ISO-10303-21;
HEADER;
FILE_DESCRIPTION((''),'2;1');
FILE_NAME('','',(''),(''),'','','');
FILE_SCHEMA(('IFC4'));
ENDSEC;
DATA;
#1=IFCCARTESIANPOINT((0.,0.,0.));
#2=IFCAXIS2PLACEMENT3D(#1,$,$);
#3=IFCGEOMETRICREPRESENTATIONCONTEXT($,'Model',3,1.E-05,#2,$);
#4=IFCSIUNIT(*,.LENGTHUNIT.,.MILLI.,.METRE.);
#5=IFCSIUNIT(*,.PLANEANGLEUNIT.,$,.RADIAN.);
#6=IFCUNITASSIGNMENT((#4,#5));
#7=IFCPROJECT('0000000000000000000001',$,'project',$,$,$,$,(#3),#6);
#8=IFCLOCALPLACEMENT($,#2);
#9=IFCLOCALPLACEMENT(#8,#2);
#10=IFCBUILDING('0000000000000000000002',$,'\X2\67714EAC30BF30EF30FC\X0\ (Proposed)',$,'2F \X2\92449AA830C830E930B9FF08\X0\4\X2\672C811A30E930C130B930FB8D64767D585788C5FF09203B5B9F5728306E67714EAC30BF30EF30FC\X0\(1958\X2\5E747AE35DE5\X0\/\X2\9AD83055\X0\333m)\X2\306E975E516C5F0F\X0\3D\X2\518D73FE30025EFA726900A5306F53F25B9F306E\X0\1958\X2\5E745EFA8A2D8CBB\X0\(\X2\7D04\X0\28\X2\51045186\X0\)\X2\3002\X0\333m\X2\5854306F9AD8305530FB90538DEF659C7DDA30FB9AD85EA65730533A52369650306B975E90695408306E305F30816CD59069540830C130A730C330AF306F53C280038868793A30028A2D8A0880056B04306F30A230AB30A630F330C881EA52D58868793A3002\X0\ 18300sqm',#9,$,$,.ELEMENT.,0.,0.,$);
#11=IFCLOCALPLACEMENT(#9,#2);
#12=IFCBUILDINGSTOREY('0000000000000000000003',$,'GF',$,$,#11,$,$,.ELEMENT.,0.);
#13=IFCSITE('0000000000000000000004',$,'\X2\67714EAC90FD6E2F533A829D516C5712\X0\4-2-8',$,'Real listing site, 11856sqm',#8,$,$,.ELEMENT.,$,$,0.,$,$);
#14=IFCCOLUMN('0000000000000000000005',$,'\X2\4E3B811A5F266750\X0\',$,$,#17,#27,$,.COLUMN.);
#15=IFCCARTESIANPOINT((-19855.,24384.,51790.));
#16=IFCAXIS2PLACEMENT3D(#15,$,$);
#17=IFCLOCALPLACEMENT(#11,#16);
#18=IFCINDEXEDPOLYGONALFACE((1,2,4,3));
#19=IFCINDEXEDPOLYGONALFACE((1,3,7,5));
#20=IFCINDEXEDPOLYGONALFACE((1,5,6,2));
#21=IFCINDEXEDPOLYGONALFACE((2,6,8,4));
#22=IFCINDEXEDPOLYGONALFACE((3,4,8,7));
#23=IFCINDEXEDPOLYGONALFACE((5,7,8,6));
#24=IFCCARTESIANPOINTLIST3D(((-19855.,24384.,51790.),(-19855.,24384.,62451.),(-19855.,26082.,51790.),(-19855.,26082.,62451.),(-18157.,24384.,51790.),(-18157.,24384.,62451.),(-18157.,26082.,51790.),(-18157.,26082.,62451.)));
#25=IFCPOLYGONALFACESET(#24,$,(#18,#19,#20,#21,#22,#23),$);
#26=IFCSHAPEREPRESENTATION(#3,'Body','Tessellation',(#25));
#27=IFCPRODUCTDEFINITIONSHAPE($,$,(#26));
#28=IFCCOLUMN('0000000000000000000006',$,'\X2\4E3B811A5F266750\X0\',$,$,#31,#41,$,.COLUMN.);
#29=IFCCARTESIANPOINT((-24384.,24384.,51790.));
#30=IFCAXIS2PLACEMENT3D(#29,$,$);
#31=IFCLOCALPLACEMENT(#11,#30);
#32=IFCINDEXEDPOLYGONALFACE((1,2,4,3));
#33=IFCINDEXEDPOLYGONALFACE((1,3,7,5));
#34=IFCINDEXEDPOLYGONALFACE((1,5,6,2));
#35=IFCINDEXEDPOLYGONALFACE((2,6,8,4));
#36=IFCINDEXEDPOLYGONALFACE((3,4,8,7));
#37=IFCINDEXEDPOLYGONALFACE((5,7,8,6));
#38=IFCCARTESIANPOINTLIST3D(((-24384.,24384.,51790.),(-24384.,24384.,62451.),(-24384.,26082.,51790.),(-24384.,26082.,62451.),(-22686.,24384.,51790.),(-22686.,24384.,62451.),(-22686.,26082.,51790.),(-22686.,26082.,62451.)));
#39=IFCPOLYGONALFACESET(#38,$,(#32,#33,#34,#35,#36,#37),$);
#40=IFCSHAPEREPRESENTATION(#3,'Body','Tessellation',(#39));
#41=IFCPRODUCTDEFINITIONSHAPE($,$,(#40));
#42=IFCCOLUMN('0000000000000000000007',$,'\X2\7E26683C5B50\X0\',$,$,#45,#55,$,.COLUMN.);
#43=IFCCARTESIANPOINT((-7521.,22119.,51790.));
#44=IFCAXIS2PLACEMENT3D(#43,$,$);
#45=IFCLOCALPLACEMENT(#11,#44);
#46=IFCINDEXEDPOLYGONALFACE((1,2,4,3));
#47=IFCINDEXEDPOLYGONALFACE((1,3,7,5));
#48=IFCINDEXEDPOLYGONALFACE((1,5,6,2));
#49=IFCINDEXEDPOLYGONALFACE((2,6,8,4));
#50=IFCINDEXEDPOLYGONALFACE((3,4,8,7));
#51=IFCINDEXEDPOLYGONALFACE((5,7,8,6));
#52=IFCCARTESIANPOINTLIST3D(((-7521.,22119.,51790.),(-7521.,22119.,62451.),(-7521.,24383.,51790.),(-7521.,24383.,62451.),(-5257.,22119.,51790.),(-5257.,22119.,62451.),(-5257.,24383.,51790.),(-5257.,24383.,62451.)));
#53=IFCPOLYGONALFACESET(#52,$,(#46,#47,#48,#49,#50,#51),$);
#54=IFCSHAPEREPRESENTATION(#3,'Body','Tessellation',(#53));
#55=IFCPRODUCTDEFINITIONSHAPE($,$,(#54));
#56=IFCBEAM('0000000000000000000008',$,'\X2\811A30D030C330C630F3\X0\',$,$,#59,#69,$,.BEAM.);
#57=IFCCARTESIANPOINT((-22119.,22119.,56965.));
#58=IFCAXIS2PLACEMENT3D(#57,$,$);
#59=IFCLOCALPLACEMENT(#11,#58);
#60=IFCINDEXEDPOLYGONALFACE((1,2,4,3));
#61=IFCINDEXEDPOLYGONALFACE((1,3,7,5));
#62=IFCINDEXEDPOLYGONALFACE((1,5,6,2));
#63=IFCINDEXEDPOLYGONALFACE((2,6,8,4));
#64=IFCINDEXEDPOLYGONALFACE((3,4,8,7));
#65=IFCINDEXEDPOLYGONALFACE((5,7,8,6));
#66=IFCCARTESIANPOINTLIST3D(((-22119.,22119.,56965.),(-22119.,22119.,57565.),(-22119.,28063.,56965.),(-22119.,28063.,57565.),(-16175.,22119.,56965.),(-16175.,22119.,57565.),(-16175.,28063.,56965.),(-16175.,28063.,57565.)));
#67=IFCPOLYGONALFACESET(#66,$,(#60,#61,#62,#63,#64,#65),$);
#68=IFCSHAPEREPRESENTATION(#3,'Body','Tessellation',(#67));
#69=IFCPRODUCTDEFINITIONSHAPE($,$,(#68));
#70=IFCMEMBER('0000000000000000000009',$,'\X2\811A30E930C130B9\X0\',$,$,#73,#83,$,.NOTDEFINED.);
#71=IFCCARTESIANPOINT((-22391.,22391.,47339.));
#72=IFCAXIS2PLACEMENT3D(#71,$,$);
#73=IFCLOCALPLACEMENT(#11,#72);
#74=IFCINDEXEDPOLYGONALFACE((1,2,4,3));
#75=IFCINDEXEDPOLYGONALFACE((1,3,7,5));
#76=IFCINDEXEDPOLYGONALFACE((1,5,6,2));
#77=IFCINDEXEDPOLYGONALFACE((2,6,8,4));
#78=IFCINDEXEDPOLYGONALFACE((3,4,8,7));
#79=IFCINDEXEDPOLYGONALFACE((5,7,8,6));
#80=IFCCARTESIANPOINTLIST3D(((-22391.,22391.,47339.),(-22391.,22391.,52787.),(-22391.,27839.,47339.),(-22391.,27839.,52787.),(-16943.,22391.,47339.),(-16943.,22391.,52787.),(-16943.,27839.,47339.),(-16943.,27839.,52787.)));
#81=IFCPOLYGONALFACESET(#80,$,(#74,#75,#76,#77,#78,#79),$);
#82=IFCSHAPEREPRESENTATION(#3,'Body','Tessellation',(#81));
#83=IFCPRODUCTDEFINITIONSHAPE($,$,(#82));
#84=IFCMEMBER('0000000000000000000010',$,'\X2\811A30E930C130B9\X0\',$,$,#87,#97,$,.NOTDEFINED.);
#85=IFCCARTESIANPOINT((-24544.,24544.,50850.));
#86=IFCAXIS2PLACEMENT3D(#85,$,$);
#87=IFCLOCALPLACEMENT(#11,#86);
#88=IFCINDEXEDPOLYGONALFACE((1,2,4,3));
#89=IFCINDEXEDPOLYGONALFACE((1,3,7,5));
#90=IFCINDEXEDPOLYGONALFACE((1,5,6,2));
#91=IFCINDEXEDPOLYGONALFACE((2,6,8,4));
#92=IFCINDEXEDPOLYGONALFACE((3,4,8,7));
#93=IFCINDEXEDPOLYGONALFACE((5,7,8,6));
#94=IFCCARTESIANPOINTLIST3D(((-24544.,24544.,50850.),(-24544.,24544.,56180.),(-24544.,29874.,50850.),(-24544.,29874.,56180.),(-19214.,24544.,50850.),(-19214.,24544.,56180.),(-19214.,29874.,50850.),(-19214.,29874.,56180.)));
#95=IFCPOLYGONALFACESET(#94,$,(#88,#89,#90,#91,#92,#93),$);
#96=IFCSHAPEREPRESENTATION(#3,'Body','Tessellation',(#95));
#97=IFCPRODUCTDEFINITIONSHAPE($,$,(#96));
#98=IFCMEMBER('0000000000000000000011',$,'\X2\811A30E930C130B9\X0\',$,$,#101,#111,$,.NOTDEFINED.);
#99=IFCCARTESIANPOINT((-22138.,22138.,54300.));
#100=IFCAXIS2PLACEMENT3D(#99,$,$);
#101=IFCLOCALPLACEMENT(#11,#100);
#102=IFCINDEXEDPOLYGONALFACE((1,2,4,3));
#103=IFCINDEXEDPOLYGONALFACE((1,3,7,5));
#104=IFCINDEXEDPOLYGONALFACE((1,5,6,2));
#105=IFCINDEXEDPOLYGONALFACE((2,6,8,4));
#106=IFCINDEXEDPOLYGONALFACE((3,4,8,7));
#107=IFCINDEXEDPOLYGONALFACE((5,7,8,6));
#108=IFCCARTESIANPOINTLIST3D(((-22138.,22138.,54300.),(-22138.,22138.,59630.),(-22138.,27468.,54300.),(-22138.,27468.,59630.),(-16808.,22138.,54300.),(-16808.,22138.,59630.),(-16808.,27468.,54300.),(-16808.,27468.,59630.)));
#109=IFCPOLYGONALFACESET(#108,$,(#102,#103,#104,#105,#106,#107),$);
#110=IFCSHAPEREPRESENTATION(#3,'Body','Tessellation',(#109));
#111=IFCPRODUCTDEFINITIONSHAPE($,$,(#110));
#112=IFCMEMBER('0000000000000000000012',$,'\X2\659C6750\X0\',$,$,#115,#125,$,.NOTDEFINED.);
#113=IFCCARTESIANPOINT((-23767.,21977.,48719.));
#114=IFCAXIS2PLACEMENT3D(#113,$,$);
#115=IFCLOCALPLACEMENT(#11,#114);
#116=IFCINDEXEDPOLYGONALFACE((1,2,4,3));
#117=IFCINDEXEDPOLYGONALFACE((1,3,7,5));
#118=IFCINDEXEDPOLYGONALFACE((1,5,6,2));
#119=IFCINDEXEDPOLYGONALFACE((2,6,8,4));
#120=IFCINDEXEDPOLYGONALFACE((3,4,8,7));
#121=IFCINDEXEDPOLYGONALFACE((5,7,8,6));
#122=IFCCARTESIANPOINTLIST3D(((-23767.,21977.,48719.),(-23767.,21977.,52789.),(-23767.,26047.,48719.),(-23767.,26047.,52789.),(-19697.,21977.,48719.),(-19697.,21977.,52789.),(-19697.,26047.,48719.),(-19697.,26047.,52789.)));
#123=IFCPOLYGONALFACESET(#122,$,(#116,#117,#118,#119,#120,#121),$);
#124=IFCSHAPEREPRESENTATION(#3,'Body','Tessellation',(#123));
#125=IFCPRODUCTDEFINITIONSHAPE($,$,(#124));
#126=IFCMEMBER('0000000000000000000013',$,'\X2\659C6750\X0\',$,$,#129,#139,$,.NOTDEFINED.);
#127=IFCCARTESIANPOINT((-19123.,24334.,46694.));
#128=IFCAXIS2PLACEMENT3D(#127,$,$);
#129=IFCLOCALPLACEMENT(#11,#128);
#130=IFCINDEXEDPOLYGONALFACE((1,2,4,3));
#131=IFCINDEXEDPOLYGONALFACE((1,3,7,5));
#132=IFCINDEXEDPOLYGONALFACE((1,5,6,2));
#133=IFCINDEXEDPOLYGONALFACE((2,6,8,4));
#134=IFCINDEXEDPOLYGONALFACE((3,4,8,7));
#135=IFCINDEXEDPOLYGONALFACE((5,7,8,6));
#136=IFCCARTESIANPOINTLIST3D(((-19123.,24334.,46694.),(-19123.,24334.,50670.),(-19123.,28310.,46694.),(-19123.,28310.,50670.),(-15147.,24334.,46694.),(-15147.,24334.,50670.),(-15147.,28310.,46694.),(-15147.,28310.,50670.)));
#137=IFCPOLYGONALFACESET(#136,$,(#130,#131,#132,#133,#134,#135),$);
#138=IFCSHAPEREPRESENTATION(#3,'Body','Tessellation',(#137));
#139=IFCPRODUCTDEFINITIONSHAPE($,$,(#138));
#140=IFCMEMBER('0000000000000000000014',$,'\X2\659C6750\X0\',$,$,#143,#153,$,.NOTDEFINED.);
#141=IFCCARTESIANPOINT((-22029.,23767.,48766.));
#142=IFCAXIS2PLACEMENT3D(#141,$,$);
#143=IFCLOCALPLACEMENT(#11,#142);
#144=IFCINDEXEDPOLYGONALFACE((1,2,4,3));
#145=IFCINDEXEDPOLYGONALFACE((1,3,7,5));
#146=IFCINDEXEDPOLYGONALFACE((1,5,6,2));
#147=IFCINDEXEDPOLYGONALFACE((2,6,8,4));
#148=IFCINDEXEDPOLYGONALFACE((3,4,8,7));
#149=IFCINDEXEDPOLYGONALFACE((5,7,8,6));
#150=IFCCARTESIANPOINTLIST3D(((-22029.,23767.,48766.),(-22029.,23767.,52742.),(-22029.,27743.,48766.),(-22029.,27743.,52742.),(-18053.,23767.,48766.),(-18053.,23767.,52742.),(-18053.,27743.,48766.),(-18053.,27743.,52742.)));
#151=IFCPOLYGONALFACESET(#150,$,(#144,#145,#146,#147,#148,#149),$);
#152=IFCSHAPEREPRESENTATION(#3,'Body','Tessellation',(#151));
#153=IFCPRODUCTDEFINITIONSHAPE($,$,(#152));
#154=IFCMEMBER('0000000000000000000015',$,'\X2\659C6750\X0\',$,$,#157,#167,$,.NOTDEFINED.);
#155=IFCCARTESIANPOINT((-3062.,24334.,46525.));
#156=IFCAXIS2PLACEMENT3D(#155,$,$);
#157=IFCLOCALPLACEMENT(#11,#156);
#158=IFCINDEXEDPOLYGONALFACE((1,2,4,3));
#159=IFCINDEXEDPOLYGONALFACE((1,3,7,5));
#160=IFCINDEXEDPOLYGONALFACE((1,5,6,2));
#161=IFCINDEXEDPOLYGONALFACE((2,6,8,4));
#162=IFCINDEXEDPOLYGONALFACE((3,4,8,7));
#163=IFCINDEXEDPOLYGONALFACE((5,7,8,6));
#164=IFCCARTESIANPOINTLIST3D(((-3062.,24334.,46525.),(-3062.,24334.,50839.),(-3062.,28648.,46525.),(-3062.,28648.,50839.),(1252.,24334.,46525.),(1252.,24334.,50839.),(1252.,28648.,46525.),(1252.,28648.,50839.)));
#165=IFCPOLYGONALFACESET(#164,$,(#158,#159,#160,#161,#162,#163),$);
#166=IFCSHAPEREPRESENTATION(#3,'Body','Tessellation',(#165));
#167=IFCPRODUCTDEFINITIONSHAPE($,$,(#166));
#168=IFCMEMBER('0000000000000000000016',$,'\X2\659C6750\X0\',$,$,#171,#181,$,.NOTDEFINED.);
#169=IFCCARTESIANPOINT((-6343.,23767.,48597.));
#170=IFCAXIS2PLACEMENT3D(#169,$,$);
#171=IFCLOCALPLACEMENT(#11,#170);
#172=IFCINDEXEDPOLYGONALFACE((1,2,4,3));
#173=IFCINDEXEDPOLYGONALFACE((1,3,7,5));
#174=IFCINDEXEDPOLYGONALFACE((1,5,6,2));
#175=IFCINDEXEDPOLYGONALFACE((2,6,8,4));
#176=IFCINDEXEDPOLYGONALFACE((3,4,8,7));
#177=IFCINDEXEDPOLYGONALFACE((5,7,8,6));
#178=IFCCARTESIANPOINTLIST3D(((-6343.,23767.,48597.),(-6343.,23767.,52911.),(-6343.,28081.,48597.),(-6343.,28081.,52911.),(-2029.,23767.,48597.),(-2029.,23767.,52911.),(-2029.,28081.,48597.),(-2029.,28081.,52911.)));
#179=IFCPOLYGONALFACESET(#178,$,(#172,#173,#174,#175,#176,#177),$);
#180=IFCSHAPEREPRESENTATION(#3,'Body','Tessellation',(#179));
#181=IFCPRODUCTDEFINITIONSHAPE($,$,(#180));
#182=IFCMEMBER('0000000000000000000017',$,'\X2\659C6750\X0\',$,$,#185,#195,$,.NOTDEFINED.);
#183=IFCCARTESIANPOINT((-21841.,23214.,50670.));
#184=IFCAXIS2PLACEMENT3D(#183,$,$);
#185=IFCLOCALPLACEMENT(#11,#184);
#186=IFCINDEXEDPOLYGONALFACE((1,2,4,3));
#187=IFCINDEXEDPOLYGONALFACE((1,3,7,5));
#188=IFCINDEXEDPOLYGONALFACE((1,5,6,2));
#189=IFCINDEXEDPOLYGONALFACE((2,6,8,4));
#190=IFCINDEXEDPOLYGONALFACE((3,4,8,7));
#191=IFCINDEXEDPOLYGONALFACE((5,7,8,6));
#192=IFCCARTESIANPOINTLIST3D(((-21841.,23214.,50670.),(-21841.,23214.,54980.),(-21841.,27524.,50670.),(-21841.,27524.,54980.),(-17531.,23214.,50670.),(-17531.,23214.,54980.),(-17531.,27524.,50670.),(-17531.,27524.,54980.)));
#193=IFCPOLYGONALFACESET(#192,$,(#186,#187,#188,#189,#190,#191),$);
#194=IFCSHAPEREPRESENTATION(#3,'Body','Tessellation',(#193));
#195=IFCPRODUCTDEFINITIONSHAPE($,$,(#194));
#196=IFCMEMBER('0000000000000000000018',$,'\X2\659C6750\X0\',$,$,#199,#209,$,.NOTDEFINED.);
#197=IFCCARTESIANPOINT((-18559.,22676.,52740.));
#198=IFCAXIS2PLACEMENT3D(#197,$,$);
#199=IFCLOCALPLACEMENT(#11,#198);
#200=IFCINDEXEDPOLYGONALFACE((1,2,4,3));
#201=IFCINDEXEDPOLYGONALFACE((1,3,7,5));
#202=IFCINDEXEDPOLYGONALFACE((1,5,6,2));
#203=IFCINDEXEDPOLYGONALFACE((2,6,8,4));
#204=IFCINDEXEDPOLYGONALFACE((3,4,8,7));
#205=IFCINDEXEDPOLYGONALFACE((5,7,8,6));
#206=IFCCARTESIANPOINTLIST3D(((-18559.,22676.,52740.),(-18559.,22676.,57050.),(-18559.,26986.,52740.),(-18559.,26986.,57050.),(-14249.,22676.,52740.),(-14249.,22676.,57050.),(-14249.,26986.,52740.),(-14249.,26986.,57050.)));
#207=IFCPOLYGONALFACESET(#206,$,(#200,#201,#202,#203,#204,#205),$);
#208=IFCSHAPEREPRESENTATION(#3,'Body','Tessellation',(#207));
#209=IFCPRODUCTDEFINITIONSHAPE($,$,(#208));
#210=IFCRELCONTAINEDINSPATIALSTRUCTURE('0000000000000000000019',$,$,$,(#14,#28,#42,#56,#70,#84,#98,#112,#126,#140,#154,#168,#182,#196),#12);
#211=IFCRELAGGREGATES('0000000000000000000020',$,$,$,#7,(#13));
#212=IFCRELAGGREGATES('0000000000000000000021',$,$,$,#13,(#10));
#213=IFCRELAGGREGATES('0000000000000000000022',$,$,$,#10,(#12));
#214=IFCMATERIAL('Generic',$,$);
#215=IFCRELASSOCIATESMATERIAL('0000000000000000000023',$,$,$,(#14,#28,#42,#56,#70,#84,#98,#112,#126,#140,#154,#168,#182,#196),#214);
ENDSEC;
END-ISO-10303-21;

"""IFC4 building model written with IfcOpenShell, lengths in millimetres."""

from ifc_helpers import new_model, si_unit, frame, frame_2d, origin, place, context, project, spatial, rectangle, extrude, material, element, save


model = new_model("IFC4")

# Units and contexts
model_context = context("Model", 3, precision=1e-05, world=origin())
ifc_project = project(units=[si_unit("LENGTHUNIT", "METRE", prefix="MILLI"), si_unit("PLANEANGLEUNIT", "RADIAN")], contexts=[model_context])

# Site, building, storey
site_placement = place(None, origin())
site = spatial("IfcSite", under=ifc_project, at=site_placement, Name="東京都港区芝公園4-2-8", ObjectType="Real listing site, 11856sqm", CompositionType="ELEMENT", RefElevation=0.0)
building_placement = place(site_placement, origin())
building = spatial("IfcBuilding", under=site, at=building_placement, Name="東京タワー (Proposed)", ObjectType="2F 鉄骨トラス（4本脚ラチス・赤白塗装）※実在の東京タワー(1958年竣工/高さ333m)の非公式3D再現。建物¥は史実の1958年建設費(約28億円)。333m塔は高さ・道路斜線・高度地区制限に非適合のため法適合チェックは参考表示。設計者欄はアカウント自動表示。 18300sqm", CompositionType="ELEMENT", ElevationOfRefHeight=0.0, ElevationOfTerrain=0.0)
storey_placement = place(building_placement, origin())
storey = spatial("IfcBuildingStorey", under=building, at=storey_placement, Name="GF", CompositionType="ELEMENT", Elevation=0.0)

# Columns
ifc_material = material(Name="Generic")
column_1_placement = place(storey_placement, frame((-19855.0, 24384.0, 51790.0)))
element("IfcColumn", 1, at=column_1_placement, inside=storey, material=ifc_material, Name="主脚弦材", PredefinedType="COLUMN", context=model_context, shape_type="SweptSolid", body=[
    extrude(rectangle(XDim=1698.0, YDim=1698.0, at=frame_2d((849.0, 849.0))), frame((-19855.0, 24384.0, 51790.0)), (0.0, 0.0, 1.0), 10661.0),
])
column_2_placement = place(storey_placement, frame((-24384.0, 24384.0, 51790.0)))
element("IfcColumn", 2, at=column_2_placement, inside=storey, material=ifc_material, Name="主脚弦材", PredefinedType="COLUMN", context=model_context, shape_type="SweptSolid", body=[
    extrude(rectangle(XDim=1698.0, YDim=1698.0, at=frame_2d((849.0, 849.0))), frame((-24384.0, 24384.0, 51790.0)), (0.0, 0.0, 1.0), 10661.0),
])
column_3_placement = place(storey_placement, frame((-7521.0, 22119.0, 51790.0)))
element("IfcColumn", 3, at=column_3_placement, inside=storey, material=ifc_material, Name="縦格子", PredefinedType="COLUMN", context=model_context, shape_type="SweptSolid", body=[
    extrude(rectangle(XDim=2264.0, YDim=2264.0, at=frame_2d((1132.0, 1132.0))), frame((-7521.0, 22119.0, 51790.0)), (0.0, 0.0, 1.0), 10661.0),
])

# Beam
beam_1_placement = place(storey_placement, frame((-22119.0, 22119.0, 56965.0)))
element("IfcBeam", 4, at=beam_1_placement, inside=storey, material=ifc_material, Name="脚バッテン", PredefinedType="BEAM", context=model_context, shape_type="SweptSolid", body=[
    extrude(rectangle(XDim=5944.0, YDim=5944.0, at=frame_2d((2972.0, 2972.0))), frame((-22119.0, 22119.0, 56965.0)), (0.0, 0.0, 1.0), 600.0),
])

# Members
member_1_placement = place(storey_placement, frame((-22391.0, 22391.0, 47339.0)))
element("IfcMember", 5, at=member_1_placement, inside=storey, material=ifc_material, Name="脚ラチス", PredefinedType="NOTDEFINED", context=model_context, shape_type="SweptSolid", body=[
    extrude(rectangle(XDim=5448.0, YDim=5448.0, at=frame_2d((2724.0, 2724.0))), frame((-22391.0, 22391.0, 47339.0)), (0.0, 0.0, 1.0), 5448.0),
])
member_2_placement = place(storey_placement, frame((-24544.0, 24544.0, 50850.0)))
element("IfcMember", 6, at=member_2_placement, inside=storey, material=ifc_material, Name="脚ラチス", PredefinedType="NOTDEFINED", context=model_context, shape_type="SweptSolid", body=[
    extrude(rectangle(XDim=5330.0, YDim=5330.0, at=frame_2d((2665.0, 2665.0))), frame((-24544.0, 24544.0, 50850.0)), (0.0, 0.0, 1.0), 5330.0),
])
member_3_placement = place(storey_placement, frame((-22138.0, 22138.0, 54300.0)))
element("IfcMember", 7, at=member_3_placement, inside=storey, material=ifc_material, Name="脚ラチス", PredefinedType="NOTDEFINED", context=model_context, shape_type="SweptSolid", body=[
    extrude(rectangle(XDim=5330.0, YDim=5330.0, at=frame_2d((2665.0, 2665.0))), frame((-22138.0, 22138.0, 54300.0)), (0.0, 0.0, 1.0), 5330.0),
])
member_4_placement = place(storey_placement, frame((-23767.0, 21977.0, 48719.0)))
element("IfcMember", 8, at=member_4_placement, inside=storey, material=ifc_material, Name="斜材", PredefinedType="NOTDEFINED", context=model_context, shape_type="SweptSolid", body=[
    extrude(rectangle(XDim=4070.0, YDim=4070.0, at=frame_2d((2035.0, 2035.0))), frame((-23767.0, 21977.0, 48719.0)), (0.0, 0.0, 1.0), 4070.0),
])
member_5_placement = place(storey_placement, frame((-19123.0, 24334.0, 46694.0)))
element("IfcMember", 9, at=member_5_placement, inside=storey, material=ifc_material, Name="斜材", PredefinedType="NOTDEFINED", context=model_context, shape_type="SweptSolid", body=[
    extrude(rectangle(XDim=3976.0, YDim=3976.0, at=frame_2d((1988.0, 1988.0))), frame((-19123.0, 24334.0, 46694.0)), (0.0, 0.0, 1.0), 3976.0),
])
member_6_placement = place(storey_placement, frame((-22029.0, 23767.0, 48766.0)))
element("IfcMember", 10, at=member_6_placement, inside=storey, material=ifc_material, Name="斜材", PredefinedType="NOTDEFINED", context=model_context, shape_type="SweptSolid", body=[
    extrude(rectangle(XDim=3976.0, YDim=3976.0, at=frame_2d((1988.0, 1988.0))), frame((-22029.0, 23767.0, 48766.0)), (0.0, 0.0, 1.0), 3976.0),
])
member_7_placement = place(storey_placement, frame((-3062.0, 24334.0, 46525.0)))
element("IfcMember", 11, at=member_7_placement, inside=storey, material=ifc_material, Name="斜材", PredefinedType="NOTDEFINED", context=model_context, shape_type="SweptSolid", body=[
    extrude(rectangle(XDim=4314.0, YDim=4314.0, at=frame_2d((2157.0, 2157.0))), frame((-3062.0, 24334.0, 46525.0)), (0.0, 0.0, 1.0), 4314.0),
])
member_8_placement = place(storey_placement, frame((-6343.0, 23767.0, 48597.0)))
element("IfcMember", 12, at=member_8_placement, inside=storey, material=ifc_material, Name="斜材", PredefinedType="NOTDEFINED", context=model_context, shape_type="SweptSolid", body=[
    extrude(rectangle(XDim=4314.0, YDim=4314.0, at=frame_2d((2157.0, 2157.0))), frame((-6343.0, 23767.0, 48597.0)), (0.0, 0.0, 1.0), 4314.0),
])
member_9_placement = place(storey_placement, frame((-21841.0, 23214.0, 50670.0)))
element("IfcMember", 13, at=member_9_placement, inside=storey, material=ifc_material, Name="斜材", PredefinedType="NOTDEFINED", context=model_context, shape_type="SweptSolid", body=[
    extrude(rectangle(XDim=4310.0, YDim=4310.0, at=frame_2d((2155.0, 2155.0))), frame((-21841.0, 23214.0, 50670.0)), (0.0, 0.0, 1.0), 4310.0),
])
member_10_placement = place(storey_placement, frame((-18559.0, 22676.0, 52740.0)))
element("IfcMember", 14, at=member_10_placement, inside=storey, material=ifc_material, Name="斜材", PredefinedType="NOTDEFINED", context=model_context, shape_type="SweptSolid", body=[
    extrude(rectangle(XDim=4310.0, YDim=4310.0, at=frame_2d((2155.0, 2155.0))), frame((-18559.0, 22676.0, 52740.0)), (0.0, 0.0, 1.0), 4310.0),
])

save(model, "model.ifc")
